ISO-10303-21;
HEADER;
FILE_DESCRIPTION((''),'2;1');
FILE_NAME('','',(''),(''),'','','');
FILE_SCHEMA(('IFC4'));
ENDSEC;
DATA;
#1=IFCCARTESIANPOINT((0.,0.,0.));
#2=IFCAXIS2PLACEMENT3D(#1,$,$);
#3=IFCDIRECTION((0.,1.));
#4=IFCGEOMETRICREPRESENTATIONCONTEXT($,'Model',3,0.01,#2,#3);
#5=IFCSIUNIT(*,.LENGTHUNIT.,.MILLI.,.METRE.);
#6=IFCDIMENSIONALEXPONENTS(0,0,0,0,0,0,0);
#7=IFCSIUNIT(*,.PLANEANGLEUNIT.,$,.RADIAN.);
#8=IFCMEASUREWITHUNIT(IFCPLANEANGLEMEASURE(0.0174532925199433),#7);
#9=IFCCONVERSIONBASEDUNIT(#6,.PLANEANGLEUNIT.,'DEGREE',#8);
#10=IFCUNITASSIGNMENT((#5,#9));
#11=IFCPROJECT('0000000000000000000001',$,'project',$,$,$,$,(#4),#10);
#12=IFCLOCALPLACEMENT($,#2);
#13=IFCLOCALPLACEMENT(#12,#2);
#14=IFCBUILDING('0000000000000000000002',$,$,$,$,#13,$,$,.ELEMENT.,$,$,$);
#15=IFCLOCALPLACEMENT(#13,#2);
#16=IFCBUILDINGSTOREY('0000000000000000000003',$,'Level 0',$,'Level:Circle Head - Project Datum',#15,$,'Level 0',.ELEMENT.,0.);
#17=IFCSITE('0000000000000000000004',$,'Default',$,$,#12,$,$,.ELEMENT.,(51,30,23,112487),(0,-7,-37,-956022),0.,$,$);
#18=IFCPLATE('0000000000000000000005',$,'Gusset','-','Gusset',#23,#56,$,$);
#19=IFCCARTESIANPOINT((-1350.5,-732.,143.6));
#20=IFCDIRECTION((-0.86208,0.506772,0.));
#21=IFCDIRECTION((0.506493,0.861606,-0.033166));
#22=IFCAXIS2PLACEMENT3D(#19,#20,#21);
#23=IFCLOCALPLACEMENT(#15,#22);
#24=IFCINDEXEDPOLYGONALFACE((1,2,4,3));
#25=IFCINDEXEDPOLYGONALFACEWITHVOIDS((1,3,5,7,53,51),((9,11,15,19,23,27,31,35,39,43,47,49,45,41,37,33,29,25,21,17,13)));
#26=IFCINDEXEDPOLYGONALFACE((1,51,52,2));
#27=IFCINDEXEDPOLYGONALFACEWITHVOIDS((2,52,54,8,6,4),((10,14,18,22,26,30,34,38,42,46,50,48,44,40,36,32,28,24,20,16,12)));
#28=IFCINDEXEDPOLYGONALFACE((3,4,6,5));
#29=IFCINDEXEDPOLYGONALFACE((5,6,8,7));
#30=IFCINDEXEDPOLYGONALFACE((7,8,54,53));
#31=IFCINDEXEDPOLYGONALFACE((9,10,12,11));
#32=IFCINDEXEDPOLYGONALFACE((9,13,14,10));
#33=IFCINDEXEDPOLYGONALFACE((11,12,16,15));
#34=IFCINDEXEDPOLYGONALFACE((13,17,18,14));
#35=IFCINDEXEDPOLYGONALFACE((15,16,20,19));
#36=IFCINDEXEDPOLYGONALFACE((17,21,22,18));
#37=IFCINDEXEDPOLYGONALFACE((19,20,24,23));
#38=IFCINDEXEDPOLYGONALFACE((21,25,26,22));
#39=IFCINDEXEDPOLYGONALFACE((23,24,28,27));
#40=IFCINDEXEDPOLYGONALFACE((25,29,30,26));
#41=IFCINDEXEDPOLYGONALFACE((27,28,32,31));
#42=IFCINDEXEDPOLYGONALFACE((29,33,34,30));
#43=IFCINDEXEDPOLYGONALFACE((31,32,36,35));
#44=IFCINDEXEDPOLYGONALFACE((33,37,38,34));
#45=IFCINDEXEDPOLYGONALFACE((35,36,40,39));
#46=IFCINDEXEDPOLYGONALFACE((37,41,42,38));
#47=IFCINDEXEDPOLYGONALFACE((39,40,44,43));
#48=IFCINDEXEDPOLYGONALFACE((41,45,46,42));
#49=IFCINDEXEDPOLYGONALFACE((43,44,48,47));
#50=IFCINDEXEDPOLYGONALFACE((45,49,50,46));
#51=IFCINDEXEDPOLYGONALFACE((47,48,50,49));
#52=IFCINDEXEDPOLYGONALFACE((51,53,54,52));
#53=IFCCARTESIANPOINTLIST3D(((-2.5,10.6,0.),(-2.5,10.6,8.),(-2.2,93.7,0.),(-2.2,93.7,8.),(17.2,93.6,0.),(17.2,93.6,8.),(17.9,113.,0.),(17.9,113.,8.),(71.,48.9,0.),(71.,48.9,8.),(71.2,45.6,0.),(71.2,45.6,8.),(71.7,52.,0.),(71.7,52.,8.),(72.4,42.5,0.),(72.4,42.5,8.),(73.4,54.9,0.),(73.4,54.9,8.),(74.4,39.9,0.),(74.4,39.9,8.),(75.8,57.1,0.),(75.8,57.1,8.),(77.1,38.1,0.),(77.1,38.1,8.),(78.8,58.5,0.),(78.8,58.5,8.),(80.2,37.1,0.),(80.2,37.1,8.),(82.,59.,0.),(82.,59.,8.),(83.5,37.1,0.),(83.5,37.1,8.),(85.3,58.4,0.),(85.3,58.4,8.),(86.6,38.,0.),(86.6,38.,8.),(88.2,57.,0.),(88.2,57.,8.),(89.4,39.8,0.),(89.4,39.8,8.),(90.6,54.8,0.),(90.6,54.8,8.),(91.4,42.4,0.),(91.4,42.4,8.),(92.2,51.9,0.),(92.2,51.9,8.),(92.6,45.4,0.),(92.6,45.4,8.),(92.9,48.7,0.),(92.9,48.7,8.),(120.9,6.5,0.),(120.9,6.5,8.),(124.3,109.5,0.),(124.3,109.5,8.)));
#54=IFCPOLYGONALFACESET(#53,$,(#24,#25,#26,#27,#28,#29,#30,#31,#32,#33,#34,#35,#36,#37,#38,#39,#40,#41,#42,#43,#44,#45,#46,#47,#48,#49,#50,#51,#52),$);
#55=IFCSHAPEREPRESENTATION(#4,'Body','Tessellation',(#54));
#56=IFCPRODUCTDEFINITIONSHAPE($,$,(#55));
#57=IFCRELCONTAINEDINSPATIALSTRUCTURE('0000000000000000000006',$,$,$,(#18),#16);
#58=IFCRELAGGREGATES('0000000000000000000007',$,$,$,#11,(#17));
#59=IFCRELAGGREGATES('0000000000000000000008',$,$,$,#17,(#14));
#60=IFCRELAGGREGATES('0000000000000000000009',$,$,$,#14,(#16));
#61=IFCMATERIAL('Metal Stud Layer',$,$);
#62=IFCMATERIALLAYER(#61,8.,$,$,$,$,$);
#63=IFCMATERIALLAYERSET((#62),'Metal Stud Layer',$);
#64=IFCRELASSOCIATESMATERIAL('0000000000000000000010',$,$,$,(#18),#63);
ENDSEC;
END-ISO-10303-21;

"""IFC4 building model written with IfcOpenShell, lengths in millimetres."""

from ifc_helpers import new_model, entity, si_unit, converted_unit, point, direction, frame, frame_2d, origin, origin_with_axes, origin_2d_with_axis, place, context, project, spatial, polyline, circle_curve, line_curve, trimmed, segment, composite_curve, circle, outline, extrude, material, layer, layer_set, element, save


model = new_model("IFC4")

# Units and contexts
model_context = context("Model", 3, precision=0.01, world=origin(), true_north=direction((0.0, 1.0)))
ifc_project = project(units=[si_unit("LENGTHUNIT", "METRE", prefix="MILLI"), converted_unit("PLANEANGLEUNIT", "DEGREE", entity("IfcPlaneAngleMeasure", 0.0174532925199433), si_unit("PLANEANGLEUNIT", "RADIAN"), dimensions=[0, 0, 0, 0, 0, 0, 0])], contexts=[model_context])

# Site, building, storey
site_placement = place(None, origin())
site = spatial("IfcSite", under=ifc_project, at=site_placement, Name="Default", CompositionType="ELEMENT", RefLatitude=(51, 30, 23, 112487), RefLongitude=(0, -7, -37, -956022), RefElevation=0.0)
building_placement = place(site_placement, origin())
building = spatial("IfcBuilding", under=site, at=building_placement, CompositionType="ELEMENT")
storey_placement = place(building_placement, origin())
storey = spatial("IfcBuildingStorey", under=building, at=storey_placement, Name="Level 0", ObjectType="Level:Circle Head - Project Datum", LongName="Level 0", CompositionType="ELEMENT", Elevation=0.0)

# Plate, openings
ifc_material_1 = material(Name="Metal Stud Layer")
ifc_layer_1 = layer(ifc_material_1, 8.0)
ifc_layer_set_1 = layer_set([ifc_layer_1], Name="Metal Stud Layer")
plate_1_placement = place(storey_placement, frame((-1350.5, -732.0, 143.6), z_axis=(-0.86208, 0.506772, 0.0), x_axis=(0.506493, 0.861606, -0.033166)))
plate_1 = element("IfcPlate", 1, at=plate_1_placement, inside=storey, material=ifc_layer_set_1, Name="Gusset", Description="-", ObjectType="Gusset", context=model_context, shape_type="SweptSolid", body=[
    extrude(outline(polyline([(120.9, 6.5), (124.3, 109.5), (17.9, 113.0), (17.2, 93.6), (-2.2, 93.7), (-2.5, 10.6), (120.9, 6.5)])), origin_with_axes(), (0.0, 0.0, 1.0), 8.0),
])
opening_1_placement = place(plate_1_placement, origin_with_axes())
element("IfcOpeningElement", 2, at=opening_1_placement, cuts=plate_1, ObjectType="Opening", context=model_context, shape_type="SweptSolid", body=[
    extrude(outline(composite_curve([segment(trimmed(line_curve((17.2, 93.6), (-0.999992, 0.004054), 19.425957), [point((17.2, 93.6))], [point((-2.2, 93.7))], True, "CARTESIAN"), True, "CONTINUOUS"), segment(trimmed(circle_curve(frame_2d((-2.1, 113.7), x_axis=(1.0, 0.0)), 20.0), [point((-2.2, 93.7))], [point((17.9, 113.0))], True, "CARTESIAN"), True, "CONTINUOUS"), segment(trimmed(line_curve((17.9, 113.0), (-0.033166, -0.99945), 19.425957), [point((17.9, 113.0))], [point((17.2, 93.6))], True, "CARTESIAN"), True, "CONTINUOUS")], self_intersect="UNKNOWN")), origin(), (0.0, 0.0, 1.0), 8.0),
])
opening_2_placement = place(plate_1_placement, frame((81.9, 48.0, 8.5), z_axis=(0.0, 0.0, -1.0), x_axis=(0.862509, -0.506042, 0.0)))
element("IfcOpeningElement", 3, at=opening_2_placement, cuts=plate_1, ObjectType="Opening", context=model_context, shape_type="SweptSolid", body=[
    extrude(circle(Radius=11.0, at=origin_2d_with_axis()), origin(), (0.0, 0.0, 1.0), 9.0),
])

save(model, "model.ifc")
